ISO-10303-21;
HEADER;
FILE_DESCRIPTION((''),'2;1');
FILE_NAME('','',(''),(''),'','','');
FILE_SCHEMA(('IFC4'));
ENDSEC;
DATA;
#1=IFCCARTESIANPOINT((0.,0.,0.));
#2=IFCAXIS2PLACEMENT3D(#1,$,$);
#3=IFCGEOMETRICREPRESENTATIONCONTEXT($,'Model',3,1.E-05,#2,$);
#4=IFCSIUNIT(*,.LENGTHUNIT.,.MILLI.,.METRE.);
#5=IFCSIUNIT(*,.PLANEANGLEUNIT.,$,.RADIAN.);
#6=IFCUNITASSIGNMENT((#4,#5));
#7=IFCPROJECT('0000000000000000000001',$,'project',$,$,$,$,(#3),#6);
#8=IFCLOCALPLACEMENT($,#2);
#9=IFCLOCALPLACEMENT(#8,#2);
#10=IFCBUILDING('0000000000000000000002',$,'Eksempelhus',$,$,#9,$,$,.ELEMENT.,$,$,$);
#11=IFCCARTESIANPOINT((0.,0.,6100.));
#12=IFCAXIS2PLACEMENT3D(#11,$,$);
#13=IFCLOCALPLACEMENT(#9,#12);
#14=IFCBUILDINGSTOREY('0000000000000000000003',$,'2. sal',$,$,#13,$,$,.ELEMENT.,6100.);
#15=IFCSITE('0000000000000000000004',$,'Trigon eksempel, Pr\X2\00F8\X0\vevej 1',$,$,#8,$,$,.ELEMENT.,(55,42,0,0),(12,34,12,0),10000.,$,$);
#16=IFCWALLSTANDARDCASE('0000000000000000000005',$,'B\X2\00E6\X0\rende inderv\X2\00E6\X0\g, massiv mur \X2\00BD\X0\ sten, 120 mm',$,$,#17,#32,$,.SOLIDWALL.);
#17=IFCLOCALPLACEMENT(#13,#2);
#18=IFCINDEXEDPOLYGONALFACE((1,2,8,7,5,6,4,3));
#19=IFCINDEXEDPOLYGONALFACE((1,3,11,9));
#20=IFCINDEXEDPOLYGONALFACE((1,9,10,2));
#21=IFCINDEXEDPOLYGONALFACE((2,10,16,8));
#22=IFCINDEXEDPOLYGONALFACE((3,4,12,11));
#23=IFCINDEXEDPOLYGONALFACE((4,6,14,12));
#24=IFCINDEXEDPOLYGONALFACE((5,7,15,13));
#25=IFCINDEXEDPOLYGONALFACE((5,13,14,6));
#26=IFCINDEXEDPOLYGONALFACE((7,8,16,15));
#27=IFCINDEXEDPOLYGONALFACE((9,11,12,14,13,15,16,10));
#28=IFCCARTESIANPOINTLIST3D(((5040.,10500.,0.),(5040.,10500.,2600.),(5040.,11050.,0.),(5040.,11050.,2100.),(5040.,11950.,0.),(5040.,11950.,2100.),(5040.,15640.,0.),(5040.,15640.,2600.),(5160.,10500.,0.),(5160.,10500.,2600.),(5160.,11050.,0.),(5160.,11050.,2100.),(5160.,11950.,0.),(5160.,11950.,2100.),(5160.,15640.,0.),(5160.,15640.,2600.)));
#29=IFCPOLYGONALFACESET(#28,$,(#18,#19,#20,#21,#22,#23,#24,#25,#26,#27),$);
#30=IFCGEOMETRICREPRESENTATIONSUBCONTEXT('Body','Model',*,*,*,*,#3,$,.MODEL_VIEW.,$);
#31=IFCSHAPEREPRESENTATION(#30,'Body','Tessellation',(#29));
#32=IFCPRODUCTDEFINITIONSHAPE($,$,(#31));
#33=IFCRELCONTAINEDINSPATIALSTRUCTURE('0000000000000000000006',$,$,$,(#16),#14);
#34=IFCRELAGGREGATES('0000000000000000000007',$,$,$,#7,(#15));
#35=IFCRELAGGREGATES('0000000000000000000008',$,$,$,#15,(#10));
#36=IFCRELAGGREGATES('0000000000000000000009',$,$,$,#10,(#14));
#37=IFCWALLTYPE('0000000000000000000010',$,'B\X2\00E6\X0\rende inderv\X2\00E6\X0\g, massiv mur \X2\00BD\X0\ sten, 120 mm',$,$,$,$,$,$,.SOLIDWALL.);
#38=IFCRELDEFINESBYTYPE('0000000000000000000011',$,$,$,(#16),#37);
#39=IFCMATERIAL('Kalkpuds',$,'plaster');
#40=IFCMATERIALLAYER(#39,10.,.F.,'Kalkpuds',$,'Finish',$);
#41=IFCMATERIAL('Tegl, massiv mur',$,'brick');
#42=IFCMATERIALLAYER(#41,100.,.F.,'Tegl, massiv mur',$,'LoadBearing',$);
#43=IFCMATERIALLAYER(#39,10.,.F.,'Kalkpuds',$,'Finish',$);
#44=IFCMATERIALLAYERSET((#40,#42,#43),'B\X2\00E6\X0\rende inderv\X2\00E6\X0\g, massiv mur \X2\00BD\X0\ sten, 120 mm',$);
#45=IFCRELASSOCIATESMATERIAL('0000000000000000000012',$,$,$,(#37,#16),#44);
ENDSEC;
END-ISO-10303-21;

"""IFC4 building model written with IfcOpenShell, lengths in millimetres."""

from ifc_helpers import new_model, si_unit, frame, origin, place, context, subcontext, project, spatial, polyline, rectangle, outline, extrude, material, layer, layer_set, layer_usage, type_object, element, save


model = new_model("IFC4")

# Units and contexts
model_context = context("Model", 3, precision=1e-05, world=origin())
body_context = subcontext(model_context, "Body", "Model", "MODEL_VIEW")
ifc_project = project(units=[si_unit("LENGTHUNIT", "METRE", prefix="MILLI"), si_unit("PLANEANGLEUNIT", "RADIAN")], contexts=[model_context])

# Site, building, storey
site_placement = place(None, origin())
site = spatial("IfcSite", under=ifc_project, at=site_placement, Name="Trigon eksempel, Prøvevej 1", CompositionType="ELEMENT", RefLatitude=(55, 42, 0, 0), RefLongitude=(12, 34, 12, 0), RefElevation=10000.0)
building_placement = place(site_placement, origin())
building = spatial("IfcBuilding", under=site, at=building_placement, Name="Eksempelhus", CompositionType="ELEMENT")
storey_placement = place(building_placement, frame((0.0, 0.0, 6100.0)))
storey = spatial("IfcBuildingStorey", under=building, at=storey_placement, Name="2. sal", CompositionType="ELEMENT", Elevation=6100.0)

# Shared definitions
ifc_material_1 = material(Name="Tegl, massiv mur", Category="brick")
ifc_material_2 = material(Name="Kalkpuds", Category="plaster")

# Wall, opening
ifc_layer_1 = layer(ifc_material_2, 10.0, ventilated=False, Name="Kalkpuds", Category="Finish")
ifc_layer_2 = layer(ifc_material_1, 100.0, ventilated=False, Name="Tegl, massiv mur", Category="LoadBearing")
ifc_layer_3 = layer(ifc_material_2, 10.0, ventilated=False, Name="Kalkpuds", Category="Finish")
ifc_layer_set_1 = layer_set([ifc_layer_1, ifc_layer_2, ifc_layer_3], Name="Bærende indervæg, massiv mur ½ sten, 120 mm")
ifc_layer_usage_1 = layer_usage(ifc_layer_set_1, "AXIS2", "POSITIVE", -60.0)
wall_type_1 = type_object("IfcWallType", Name="Bærende indervæg, massiv mur ½ sten, 120 mm", PredefinedType="SOLIDWALL", material=ifc_layer_set_1)
wall_1_placement = place(storey_placement, frame((5100.0, 10500.0, 0.0), z_axis=(0.0, 0.0, 1.0), x_axis=(0.0, 1.0, 0.0)))
wall_1 = element("IfcWallStandardCase", 1, at=wall_1_placement, inside=storey, type_object=wall_type_1, material=ifc_layer_usage_1, Name="Bærende indervæg, massiv mur ½ sten, 120 mm", PredefinedType="SOLIDWALL", context=body_context, shape_type="SweptSolid", body=[
    extrude(outline(polyline([(0.0, -60.0), (5140.0, -60.0), (5140.0, 60.0), (0.0, 60.0), (0.0, -60.0)])), origin(), (0.0, 0.0, 1.0), 2600.0),
])
opening_1_placement = place(wall_1_placement, frame((550.0, -60.0, 0.0)))
element("IfcOpeningElement", 2, at=opening_1_placement, cuts=wall_1, PredefinedType="OPENING", context=body_context, shape_type="SweptSolid", body=[
    extrude(rectangle(XDim=900.0, YDim=2100.0), frame((450.0, 0.0, 1050.0), z_axis=(0.0, 1.0, 0.0), x_axis=(1.0, 0.0, 0.0)), (0.0, 0.0, 1.0), 120.0),
])

save(model, "model.ifc")
